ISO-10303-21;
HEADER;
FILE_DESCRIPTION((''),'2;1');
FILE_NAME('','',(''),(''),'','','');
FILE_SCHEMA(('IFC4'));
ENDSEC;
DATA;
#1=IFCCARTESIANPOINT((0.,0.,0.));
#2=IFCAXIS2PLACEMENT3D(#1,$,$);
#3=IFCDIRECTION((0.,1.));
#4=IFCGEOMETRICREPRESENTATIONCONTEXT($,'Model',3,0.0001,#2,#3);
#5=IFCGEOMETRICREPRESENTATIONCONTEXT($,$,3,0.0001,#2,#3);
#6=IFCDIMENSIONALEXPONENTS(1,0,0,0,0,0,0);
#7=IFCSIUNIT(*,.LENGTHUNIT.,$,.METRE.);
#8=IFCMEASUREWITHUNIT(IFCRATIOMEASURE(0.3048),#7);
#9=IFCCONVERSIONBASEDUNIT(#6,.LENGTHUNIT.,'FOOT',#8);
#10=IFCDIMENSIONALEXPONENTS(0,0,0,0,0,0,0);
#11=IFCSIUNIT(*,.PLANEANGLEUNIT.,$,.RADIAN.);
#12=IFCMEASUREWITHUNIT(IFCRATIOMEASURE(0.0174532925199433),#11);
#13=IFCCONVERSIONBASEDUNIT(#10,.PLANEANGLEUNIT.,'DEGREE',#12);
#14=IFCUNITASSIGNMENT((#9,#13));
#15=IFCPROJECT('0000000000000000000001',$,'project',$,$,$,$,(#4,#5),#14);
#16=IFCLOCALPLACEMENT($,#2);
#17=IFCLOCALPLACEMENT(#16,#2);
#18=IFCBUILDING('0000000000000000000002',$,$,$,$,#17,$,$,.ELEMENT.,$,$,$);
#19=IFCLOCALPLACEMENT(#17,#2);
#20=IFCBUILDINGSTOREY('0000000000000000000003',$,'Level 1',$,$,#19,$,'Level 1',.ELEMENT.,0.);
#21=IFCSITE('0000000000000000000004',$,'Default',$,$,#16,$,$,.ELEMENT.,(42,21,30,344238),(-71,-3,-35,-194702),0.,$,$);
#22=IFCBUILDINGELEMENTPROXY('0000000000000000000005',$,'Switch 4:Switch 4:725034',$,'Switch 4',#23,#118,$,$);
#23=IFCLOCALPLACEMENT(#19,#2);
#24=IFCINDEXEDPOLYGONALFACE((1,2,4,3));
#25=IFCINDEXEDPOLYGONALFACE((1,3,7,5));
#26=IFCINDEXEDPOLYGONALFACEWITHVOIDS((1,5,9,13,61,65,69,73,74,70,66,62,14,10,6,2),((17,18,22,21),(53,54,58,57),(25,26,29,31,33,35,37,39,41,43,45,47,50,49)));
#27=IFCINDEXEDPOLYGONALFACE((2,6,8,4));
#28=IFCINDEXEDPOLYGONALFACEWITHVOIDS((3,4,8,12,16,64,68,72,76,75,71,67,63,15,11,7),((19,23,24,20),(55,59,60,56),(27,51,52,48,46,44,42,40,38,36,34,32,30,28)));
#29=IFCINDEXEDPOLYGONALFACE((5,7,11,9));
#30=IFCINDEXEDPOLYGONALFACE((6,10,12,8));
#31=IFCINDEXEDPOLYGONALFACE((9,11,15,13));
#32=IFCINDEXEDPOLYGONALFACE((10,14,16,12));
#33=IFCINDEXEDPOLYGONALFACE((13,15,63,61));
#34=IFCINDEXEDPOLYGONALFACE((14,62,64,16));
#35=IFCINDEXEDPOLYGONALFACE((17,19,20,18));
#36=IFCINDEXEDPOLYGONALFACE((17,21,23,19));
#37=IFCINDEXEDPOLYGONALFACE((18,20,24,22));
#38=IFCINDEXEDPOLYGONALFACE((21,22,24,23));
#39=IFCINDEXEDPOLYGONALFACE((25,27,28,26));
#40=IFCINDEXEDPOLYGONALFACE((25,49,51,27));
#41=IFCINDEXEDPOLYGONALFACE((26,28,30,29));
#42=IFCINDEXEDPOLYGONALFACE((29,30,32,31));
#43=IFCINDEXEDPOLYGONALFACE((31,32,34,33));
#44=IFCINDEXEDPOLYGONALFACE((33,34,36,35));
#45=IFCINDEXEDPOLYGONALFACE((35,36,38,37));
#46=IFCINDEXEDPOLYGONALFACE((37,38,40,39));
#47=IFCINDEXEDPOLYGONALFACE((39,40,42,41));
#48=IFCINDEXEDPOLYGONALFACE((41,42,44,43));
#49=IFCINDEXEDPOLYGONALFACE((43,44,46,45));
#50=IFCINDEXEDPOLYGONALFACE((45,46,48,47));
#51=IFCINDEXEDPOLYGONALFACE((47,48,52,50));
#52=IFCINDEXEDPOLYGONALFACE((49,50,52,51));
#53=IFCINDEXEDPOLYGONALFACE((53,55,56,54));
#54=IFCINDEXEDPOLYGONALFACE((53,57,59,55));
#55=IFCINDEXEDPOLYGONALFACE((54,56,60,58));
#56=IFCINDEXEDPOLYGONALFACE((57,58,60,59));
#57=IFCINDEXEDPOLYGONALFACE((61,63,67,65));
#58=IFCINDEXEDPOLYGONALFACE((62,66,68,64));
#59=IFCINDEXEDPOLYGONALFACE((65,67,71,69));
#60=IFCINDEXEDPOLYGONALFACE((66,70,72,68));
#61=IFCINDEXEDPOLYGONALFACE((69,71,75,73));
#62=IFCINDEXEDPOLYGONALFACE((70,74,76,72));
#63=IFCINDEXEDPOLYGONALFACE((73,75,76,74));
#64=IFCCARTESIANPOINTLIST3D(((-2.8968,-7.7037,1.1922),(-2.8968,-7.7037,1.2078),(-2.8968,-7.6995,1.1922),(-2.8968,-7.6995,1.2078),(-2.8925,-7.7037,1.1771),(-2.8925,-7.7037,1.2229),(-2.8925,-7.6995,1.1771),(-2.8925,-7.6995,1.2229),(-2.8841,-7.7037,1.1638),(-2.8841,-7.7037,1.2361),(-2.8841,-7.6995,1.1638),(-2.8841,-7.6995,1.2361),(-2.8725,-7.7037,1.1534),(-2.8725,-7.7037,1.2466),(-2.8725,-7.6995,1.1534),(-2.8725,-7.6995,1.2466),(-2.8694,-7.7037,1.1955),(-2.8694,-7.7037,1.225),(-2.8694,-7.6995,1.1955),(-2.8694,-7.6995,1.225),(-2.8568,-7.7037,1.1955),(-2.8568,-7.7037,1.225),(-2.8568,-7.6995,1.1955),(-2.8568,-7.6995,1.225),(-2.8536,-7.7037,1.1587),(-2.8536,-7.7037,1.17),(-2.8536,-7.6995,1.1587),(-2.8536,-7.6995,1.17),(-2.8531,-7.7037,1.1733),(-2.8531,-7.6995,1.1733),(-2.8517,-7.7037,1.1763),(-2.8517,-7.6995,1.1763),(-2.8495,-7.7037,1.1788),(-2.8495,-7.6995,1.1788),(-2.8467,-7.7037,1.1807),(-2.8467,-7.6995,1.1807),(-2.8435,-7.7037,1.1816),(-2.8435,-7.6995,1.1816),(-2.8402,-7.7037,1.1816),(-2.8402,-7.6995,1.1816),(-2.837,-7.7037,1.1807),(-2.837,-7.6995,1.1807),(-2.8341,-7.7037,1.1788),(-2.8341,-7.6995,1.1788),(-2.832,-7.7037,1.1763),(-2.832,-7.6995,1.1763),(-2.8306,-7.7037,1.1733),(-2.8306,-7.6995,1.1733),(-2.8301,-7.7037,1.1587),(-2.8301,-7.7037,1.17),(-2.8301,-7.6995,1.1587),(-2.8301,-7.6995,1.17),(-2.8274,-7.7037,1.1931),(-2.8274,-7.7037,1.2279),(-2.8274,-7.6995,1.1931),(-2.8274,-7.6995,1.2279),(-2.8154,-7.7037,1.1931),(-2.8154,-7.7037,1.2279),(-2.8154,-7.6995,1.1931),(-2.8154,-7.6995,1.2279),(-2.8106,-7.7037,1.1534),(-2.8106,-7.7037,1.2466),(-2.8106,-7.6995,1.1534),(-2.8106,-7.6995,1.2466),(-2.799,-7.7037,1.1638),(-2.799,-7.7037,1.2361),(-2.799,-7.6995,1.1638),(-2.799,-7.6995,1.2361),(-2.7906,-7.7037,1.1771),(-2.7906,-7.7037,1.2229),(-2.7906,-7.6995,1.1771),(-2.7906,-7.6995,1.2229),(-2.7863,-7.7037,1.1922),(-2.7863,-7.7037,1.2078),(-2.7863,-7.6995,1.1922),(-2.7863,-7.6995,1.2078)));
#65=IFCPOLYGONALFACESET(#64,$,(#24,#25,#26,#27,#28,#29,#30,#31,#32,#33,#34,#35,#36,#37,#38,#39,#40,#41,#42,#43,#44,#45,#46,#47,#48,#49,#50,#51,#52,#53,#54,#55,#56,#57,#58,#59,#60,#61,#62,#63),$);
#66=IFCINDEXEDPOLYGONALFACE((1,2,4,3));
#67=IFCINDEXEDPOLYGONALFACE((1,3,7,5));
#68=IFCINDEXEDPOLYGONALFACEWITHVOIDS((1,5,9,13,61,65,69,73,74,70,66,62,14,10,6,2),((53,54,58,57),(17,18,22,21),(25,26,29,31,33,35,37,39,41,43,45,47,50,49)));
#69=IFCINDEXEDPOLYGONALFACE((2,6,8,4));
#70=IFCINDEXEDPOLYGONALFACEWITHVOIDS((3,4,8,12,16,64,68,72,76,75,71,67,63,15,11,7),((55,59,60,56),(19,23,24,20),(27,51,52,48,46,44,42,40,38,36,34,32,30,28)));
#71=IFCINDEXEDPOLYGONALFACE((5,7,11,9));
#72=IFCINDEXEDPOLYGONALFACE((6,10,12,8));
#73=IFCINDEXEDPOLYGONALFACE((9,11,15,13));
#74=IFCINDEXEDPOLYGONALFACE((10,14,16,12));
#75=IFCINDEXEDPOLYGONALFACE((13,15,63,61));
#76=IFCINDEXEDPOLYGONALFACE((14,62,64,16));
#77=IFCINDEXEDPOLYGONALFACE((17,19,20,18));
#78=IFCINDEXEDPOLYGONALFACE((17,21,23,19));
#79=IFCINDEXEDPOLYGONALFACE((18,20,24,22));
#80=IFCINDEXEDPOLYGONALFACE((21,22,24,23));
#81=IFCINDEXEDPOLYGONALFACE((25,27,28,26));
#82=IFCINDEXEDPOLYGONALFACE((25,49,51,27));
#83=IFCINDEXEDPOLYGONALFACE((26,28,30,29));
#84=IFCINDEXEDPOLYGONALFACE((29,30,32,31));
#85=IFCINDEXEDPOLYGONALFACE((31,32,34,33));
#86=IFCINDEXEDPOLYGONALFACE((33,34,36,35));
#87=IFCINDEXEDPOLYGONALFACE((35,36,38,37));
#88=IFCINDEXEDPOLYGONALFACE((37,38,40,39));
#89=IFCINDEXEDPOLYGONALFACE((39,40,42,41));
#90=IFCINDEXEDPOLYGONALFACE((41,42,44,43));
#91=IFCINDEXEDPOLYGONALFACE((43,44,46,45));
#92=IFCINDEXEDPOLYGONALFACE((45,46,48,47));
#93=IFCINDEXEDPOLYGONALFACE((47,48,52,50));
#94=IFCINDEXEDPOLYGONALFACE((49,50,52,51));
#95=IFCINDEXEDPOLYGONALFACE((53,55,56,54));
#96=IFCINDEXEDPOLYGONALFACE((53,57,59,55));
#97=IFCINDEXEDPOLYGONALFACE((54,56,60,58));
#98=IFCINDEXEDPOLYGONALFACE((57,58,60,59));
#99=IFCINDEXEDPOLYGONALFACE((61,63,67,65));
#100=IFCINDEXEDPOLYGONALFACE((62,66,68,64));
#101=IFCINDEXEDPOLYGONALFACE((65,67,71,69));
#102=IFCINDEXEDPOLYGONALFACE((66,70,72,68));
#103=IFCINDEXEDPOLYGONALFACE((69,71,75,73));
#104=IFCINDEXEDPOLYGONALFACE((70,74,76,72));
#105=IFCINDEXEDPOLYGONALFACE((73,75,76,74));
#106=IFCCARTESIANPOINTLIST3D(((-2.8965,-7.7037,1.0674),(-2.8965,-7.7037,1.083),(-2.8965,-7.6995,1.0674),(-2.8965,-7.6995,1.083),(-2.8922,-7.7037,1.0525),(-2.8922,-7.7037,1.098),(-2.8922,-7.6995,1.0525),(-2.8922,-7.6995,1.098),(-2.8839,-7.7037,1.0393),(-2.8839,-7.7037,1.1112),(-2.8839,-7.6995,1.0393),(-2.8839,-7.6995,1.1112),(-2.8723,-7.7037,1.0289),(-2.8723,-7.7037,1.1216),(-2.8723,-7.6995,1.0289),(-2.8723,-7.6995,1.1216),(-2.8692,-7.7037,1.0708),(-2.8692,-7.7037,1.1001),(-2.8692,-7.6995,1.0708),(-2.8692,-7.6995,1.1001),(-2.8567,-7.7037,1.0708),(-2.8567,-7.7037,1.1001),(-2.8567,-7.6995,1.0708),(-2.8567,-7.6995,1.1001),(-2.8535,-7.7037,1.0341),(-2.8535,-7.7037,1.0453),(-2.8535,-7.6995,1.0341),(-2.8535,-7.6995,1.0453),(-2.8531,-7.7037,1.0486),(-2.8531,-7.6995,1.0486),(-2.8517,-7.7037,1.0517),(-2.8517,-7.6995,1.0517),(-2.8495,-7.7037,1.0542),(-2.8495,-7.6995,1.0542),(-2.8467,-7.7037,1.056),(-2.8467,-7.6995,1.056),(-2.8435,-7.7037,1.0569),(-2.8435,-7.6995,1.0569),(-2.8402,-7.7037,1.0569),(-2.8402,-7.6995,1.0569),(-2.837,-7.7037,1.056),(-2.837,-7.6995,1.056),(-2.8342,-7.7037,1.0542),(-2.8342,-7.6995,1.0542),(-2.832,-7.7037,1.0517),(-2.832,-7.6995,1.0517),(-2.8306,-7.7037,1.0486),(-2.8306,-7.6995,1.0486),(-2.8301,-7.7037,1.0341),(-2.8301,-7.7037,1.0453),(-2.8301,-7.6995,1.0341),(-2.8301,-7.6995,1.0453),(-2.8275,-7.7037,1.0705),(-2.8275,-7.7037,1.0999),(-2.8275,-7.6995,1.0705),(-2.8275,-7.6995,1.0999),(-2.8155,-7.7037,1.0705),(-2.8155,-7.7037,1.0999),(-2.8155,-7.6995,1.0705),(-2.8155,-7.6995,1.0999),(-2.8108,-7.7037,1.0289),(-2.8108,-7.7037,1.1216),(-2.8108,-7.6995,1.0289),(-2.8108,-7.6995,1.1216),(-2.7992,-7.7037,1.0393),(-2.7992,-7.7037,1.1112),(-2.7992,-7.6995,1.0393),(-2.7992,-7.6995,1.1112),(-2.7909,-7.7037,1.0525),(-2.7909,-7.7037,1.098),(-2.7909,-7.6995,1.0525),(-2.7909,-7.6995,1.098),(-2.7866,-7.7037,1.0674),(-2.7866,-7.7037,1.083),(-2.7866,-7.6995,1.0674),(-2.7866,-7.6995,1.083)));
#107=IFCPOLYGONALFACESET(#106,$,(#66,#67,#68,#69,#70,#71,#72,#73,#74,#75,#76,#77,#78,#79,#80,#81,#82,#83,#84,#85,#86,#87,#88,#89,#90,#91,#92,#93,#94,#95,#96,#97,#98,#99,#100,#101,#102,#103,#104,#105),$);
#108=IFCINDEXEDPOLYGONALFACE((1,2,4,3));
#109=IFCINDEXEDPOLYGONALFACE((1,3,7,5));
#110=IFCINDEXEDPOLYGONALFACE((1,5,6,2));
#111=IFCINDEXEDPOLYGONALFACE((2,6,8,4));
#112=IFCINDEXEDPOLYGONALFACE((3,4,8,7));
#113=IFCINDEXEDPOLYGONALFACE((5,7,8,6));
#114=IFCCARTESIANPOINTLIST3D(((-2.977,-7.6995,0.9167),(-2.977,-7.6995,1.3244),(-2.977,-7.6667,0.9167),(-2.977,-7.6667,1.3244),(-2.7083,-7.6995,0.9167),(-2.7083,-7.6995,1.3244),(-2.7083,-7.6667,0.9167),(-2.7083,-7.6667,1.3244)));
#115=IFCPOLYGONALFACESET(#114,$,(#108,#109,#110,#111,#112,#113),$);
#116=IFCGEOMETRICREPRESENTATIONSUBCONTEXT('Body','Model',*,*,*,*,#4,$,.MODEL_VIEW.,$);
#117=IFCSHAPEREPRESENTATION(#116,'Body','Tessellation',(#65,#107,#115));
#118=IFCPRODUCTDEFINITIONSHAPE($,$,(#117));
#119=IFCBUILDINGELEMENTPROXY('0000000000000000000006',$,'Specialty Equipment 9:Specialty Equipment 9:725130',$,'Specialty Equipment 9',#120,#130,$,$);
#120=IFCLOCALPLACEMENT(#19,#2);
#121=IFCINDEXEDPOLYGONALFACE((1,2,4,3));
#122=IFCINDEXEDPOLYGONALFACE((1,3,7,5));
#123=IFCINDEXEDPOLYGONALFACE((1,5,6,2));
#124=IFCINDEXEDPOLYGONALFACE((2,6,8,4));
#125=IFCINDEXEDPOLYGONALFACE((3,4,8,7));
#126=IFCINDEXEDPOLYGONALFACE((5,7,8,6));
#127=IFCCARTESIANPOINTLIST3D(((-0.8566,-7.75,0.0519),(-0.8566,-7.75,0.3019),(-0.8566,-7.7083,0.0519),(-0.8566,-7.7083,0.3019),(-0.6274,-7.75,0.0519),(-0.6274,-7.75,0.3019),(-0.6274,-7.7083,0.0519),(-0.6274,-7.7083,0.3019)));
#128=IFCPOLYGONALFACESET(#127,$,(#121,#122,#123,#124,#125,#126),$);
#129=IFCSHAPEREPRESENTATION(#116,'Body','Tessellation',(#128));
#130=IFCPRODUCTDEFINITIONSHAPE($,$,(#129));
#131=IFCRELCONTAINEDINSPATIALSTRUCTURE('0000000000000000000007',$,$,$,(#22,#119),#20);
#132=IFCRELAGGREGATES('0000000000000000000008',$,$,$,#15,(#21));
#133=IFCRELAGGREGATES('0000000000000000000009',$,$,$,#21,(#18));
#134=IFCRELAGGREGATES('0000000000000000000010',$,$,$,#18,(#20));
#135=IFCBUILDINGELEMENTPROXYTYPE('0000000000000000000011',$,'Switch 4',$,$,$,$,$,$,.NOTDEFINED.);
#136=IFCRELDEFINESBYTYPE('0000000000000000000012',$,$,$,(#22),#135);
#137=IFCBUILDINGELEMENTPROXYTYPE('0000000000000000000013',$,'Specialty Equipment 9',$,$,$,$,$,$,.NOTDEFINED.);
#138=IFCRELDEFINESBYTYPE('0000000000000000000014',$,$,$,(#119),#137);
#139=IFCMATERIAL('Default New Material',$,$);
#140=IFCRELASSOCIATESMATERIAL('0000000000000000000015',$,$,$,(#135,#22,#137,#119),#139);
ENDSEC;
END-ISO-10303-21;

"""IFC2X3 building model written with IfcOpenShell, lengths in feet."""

from ifc_helpers import new_model, entity, si_unit, converted_unit, direction, frame, frame_2d, origin, origin_2d_with_axis, place, context, subcontext, project, spatial, polyline, circle_curve, parameter, trimmed, segment, composite_curve, rectangle, outline, extrude, source, transform, mapped, material, type_object, type_shapes, element, save


model = new_model("IFC2X3")

# Units and contexts
model_context = context("Model", 3, precision=0.0001, world=origin(), true_north=direction((0.0, 1.0)))
context_of_model = context(None, 3, precision=0.0001, world=origin(), true_north=direction((0.0, 1.0)))
body_context = subcontext(model_context, "Body", "Model", "MODEL_VIEW")
ifc_project = project(units=[converted_unit("LENGTHUNIT", "FOOT", entity("IfcRatioMeasure", 0.3048), si_unit("LENGTHUNIT", "METRE"), dimensions=[1, 0, 0, 0, 0, 0, 0]), converted_unit("PLANEANGLEUNIT", "DEGREE", entity("IfcRatioMeasure", 0.0174532925199433), si_unit("PLANEANGLEUNIT", "RADIAN"), dimensions=[0, 0, 0, 0, 0, 0, 0])], contexts=[model_context, context_of_model])

# Site, building, storey
site_placement = place(None, origin())
site = spatial("IfcSite", under=ifc_project, at=site_placement, Name="Default", CompositionType="ELEMENT", RefLatitude=(42, 21, 30, 344238), RefLongitude=(-71, -3, -35, -194702), RefElevation=0.0)
building_placement = place(site_placement, origin())
building = spatial("IfcBuilding", under=site, at=building_placement, CompositionType="ELEMENT")
storey_placement = place(building_placement, origin())
storey = spatial("IfcBuildingStorey", under=building, at=storey_placement, Name="Level 1", LongName="Level 1", CompositionType="ELEMENT", Elevation=0.0)

# Shared definitions
ifc_material_1 = material(Name="Default New Material")

# Building element proxies
building_element_proxy_type_1 = type_object("IfcBuildingElementProxyType", Name="Switch 4", PredefinedType="NOTDEFINED", material=ifc_material_1)
shared_shape_1 = source(origin(), body_context, "Body", "SweptSolid", [
    extrude(outline(composite_curve([segment(polyline([(-0.0309, -0.0466), (0.0309, -0.0466)]), True, "CONTINUOUS"), segment(trimmed(circle_curve(frame_2d((-0.0003, 0.0), x_axis=(-1.0, 0.0)), 0.0561), [parameter(123.794741)], [parameter(236.205259)], True, "PARAMETER"), True, "CONTINUOUS"), segment(polyline([(0.0309, 0.0466), (-0.0309, 0.0466)]), True, "CONTINUOUS"), segment(trimmed(circle_curve(frame_2d((0.0003, 0.0), x_axis=(1.0, 0.0)), 0.0561), [parameter(123.794741)], [parameter(236.205259)], True, "PARAMETER"), True, "CONTINUOUS")], self_intersect=False), holes=[polyline([(0.0142, 0.0279), (0.0262, 0.0279), (0.0262, -0.0069), (0.0142, -0.0069), (0.0142, 0.0279)]), polyline([(-0.0153, 0.025), (-0.0153, -0.0045), (-0.0278, -0.0045), (-0.0278, 0.025), (-0.0153, 0.025)]), composite_curve([segment(polyline([(-0.012, -0.0413), (-0.012, -0.03)]), True, "CONTINUOUS"), segment(trimmed(circle_curve(frame_2d((-0.0003, -0.03), x_axis=(-1.0, 0.0)), 0.0117), [parameter(180.0)], [parameter(0.0)], True, "PARAMETER"), False, "CONTINUOUS"), segment(polyline([(0.0115, -0.03), (0.0115, -0.0413)]), True, "CONTINUOUS"), segment(polyline([(0.0115, -0.0413), (-0.012, -0.0413)]), True, "CONTINUOUS")], self_intersect=False)]), frame((-0.0011, 0.0328, 0.2833), z_axis=(0.0, 1.0, 0.0), x_axis=(-1.0, 0.0, 0.0)), (0.0, 0.0, 1.0), 0.0042),
    extrude(outline(composite_curve([segment(polyline([(-0.0308, -0.0464), (0.0308, -0.0464)]), True, "CONTINUOUS"), segment(trimmed(circle_curve(frame_2d((-0.0003, 0.0), x_axis=(-1.0, 0.0)), 0.0558), [parameter(123.794741)], [parameter(236.205259)], True, "PARAMETER"), True, "CONTINUOUS"), segment(polyline([(0.0308, 0.0464), (-0.0308, 0.0464)]), True, "CONTINUOUS"), segment(trimmed(circle_curve(frame_2d((0.0003, 0.0), x_axis=(1.0, 0.0)), 0.0558), [parameter(123.794741)], [parameter(236.205259)], True, "PARAMETER"), True, "CONTINUOUS")], self_intersect=False), holes=[polyline([(0.0141, 0.0247), (0.026, 0.0247), (0.026, -0.0047), (0.0141, -0.0047), (0.0141, 0.0247)]), polyline([(-0.0152, 0.0249), (-0.0152, -0.0045), (-0.0277, -0.0045), (-0.0277, 0.0249), (-0.0152, 0.0249)]), composite_curve([segment(polyline([(-0.012, -0.0411), (-0.012, -0.0299)]), True, "CONTINUOUS"), segment(trimmed(circle_curve(frame_2d((-0.0003, -0.0299), x_axis=(-1.0, 0.0)), 0.0117), [parameter(180.0)], [parameter(0.0)], True, "PARAMETER"), False, "CONTINUOUS"), segment(polyline([(0.0114, -0.0299), (0.0114, -0.0411)]), True, "CONTINUOUS"), segment(polyline([(0.0114, -0.0411), (-0.012, -0.0411)]), True, "CONTINUOUS")], self_intersect=False)]), frame((-0.0011, 0.0328, 0.1586), z_axis=(0.0, 1.0, 0.0), x_axis=(-1.0, 0.0, 0.0)), (0.0, 0.0, 1.0), 0.0042),
    extrude(rectangle(XDim=0.0328, YDim=0.2687, at=origin_2d_with_axis()), frame((0.0, 0.0164, 0.0), z_axis=(0.0, 0.0, 1.0), x_axis=(0.0, -1.0, 0.0)), (0.0, 0.0, 1.0), 0.4078),
])
type_shapes(building_element_proxy_type_1, [shared_shape_1])
proxy_1_placement = place(storey_placement, frame((-2.8427, -7.6667, 0.9167), z_axis=(0.0, 0.0, 1.0), x_axis=(-1.0, 0.0, 0.0)))
element("IfcBuildingElementProxy", 1, at=proxy_1_placement, inside=storey, type_object=building_element_proxy_type_1, material=ifc_material_1, Name="Switch 4:Switch 4:725034", ObjectType="Switch 4", context=body_context, shape_type="MappedRepresentation", body=[
    mapped(shared_shape_1, transform((0.0, 0.0, 0.0), scale=1.0)),
])
building_element_proxy_type_2 = type_object("IfcBuildingElementProxyType", Name="Specialty Equipment 9", PredefinedType="NOTDEFINED", material=ifc_material_1)
shared_shape_2 = source(origin(), body_context, "Body", "SweptSolid", [
    extrude(rectangle(XDim=0.0417, YDim=0.2292, at=frame_2d((0.0, 0.0), x_axis=(1.0, 0.0))), frame((0.1146, 0.0208, 0.0), z_axis=(0.0, 0.0, 1.0), x_axis=(0.0, 1.0, 0.0)), (0.0, 0.0, 1.0), 0.25),
])
type_shapes(building_element_proxy_type_2, [shared_shape_2])
proxy_2_placement = place(storey_placement, frame((-0.8566, -7.75, 0.0519)))
element("IfcBuildingElementProxy", 2, at=proxy_2_placement, inside=storey, type_object=building_element_proxy_type_2, material=ifc_material_1, Name="Specialty Equipment 9:Specialty Equipment 9:725130", ObjectType="Specialty Equipment 9", context=body_context, shape_type="MappedRepresentation", body=[
    mapped(shared_shape_2, transform((0.0, 0.0, 0.0), scale=1.0)),
])

save(model, "model.ifc")
